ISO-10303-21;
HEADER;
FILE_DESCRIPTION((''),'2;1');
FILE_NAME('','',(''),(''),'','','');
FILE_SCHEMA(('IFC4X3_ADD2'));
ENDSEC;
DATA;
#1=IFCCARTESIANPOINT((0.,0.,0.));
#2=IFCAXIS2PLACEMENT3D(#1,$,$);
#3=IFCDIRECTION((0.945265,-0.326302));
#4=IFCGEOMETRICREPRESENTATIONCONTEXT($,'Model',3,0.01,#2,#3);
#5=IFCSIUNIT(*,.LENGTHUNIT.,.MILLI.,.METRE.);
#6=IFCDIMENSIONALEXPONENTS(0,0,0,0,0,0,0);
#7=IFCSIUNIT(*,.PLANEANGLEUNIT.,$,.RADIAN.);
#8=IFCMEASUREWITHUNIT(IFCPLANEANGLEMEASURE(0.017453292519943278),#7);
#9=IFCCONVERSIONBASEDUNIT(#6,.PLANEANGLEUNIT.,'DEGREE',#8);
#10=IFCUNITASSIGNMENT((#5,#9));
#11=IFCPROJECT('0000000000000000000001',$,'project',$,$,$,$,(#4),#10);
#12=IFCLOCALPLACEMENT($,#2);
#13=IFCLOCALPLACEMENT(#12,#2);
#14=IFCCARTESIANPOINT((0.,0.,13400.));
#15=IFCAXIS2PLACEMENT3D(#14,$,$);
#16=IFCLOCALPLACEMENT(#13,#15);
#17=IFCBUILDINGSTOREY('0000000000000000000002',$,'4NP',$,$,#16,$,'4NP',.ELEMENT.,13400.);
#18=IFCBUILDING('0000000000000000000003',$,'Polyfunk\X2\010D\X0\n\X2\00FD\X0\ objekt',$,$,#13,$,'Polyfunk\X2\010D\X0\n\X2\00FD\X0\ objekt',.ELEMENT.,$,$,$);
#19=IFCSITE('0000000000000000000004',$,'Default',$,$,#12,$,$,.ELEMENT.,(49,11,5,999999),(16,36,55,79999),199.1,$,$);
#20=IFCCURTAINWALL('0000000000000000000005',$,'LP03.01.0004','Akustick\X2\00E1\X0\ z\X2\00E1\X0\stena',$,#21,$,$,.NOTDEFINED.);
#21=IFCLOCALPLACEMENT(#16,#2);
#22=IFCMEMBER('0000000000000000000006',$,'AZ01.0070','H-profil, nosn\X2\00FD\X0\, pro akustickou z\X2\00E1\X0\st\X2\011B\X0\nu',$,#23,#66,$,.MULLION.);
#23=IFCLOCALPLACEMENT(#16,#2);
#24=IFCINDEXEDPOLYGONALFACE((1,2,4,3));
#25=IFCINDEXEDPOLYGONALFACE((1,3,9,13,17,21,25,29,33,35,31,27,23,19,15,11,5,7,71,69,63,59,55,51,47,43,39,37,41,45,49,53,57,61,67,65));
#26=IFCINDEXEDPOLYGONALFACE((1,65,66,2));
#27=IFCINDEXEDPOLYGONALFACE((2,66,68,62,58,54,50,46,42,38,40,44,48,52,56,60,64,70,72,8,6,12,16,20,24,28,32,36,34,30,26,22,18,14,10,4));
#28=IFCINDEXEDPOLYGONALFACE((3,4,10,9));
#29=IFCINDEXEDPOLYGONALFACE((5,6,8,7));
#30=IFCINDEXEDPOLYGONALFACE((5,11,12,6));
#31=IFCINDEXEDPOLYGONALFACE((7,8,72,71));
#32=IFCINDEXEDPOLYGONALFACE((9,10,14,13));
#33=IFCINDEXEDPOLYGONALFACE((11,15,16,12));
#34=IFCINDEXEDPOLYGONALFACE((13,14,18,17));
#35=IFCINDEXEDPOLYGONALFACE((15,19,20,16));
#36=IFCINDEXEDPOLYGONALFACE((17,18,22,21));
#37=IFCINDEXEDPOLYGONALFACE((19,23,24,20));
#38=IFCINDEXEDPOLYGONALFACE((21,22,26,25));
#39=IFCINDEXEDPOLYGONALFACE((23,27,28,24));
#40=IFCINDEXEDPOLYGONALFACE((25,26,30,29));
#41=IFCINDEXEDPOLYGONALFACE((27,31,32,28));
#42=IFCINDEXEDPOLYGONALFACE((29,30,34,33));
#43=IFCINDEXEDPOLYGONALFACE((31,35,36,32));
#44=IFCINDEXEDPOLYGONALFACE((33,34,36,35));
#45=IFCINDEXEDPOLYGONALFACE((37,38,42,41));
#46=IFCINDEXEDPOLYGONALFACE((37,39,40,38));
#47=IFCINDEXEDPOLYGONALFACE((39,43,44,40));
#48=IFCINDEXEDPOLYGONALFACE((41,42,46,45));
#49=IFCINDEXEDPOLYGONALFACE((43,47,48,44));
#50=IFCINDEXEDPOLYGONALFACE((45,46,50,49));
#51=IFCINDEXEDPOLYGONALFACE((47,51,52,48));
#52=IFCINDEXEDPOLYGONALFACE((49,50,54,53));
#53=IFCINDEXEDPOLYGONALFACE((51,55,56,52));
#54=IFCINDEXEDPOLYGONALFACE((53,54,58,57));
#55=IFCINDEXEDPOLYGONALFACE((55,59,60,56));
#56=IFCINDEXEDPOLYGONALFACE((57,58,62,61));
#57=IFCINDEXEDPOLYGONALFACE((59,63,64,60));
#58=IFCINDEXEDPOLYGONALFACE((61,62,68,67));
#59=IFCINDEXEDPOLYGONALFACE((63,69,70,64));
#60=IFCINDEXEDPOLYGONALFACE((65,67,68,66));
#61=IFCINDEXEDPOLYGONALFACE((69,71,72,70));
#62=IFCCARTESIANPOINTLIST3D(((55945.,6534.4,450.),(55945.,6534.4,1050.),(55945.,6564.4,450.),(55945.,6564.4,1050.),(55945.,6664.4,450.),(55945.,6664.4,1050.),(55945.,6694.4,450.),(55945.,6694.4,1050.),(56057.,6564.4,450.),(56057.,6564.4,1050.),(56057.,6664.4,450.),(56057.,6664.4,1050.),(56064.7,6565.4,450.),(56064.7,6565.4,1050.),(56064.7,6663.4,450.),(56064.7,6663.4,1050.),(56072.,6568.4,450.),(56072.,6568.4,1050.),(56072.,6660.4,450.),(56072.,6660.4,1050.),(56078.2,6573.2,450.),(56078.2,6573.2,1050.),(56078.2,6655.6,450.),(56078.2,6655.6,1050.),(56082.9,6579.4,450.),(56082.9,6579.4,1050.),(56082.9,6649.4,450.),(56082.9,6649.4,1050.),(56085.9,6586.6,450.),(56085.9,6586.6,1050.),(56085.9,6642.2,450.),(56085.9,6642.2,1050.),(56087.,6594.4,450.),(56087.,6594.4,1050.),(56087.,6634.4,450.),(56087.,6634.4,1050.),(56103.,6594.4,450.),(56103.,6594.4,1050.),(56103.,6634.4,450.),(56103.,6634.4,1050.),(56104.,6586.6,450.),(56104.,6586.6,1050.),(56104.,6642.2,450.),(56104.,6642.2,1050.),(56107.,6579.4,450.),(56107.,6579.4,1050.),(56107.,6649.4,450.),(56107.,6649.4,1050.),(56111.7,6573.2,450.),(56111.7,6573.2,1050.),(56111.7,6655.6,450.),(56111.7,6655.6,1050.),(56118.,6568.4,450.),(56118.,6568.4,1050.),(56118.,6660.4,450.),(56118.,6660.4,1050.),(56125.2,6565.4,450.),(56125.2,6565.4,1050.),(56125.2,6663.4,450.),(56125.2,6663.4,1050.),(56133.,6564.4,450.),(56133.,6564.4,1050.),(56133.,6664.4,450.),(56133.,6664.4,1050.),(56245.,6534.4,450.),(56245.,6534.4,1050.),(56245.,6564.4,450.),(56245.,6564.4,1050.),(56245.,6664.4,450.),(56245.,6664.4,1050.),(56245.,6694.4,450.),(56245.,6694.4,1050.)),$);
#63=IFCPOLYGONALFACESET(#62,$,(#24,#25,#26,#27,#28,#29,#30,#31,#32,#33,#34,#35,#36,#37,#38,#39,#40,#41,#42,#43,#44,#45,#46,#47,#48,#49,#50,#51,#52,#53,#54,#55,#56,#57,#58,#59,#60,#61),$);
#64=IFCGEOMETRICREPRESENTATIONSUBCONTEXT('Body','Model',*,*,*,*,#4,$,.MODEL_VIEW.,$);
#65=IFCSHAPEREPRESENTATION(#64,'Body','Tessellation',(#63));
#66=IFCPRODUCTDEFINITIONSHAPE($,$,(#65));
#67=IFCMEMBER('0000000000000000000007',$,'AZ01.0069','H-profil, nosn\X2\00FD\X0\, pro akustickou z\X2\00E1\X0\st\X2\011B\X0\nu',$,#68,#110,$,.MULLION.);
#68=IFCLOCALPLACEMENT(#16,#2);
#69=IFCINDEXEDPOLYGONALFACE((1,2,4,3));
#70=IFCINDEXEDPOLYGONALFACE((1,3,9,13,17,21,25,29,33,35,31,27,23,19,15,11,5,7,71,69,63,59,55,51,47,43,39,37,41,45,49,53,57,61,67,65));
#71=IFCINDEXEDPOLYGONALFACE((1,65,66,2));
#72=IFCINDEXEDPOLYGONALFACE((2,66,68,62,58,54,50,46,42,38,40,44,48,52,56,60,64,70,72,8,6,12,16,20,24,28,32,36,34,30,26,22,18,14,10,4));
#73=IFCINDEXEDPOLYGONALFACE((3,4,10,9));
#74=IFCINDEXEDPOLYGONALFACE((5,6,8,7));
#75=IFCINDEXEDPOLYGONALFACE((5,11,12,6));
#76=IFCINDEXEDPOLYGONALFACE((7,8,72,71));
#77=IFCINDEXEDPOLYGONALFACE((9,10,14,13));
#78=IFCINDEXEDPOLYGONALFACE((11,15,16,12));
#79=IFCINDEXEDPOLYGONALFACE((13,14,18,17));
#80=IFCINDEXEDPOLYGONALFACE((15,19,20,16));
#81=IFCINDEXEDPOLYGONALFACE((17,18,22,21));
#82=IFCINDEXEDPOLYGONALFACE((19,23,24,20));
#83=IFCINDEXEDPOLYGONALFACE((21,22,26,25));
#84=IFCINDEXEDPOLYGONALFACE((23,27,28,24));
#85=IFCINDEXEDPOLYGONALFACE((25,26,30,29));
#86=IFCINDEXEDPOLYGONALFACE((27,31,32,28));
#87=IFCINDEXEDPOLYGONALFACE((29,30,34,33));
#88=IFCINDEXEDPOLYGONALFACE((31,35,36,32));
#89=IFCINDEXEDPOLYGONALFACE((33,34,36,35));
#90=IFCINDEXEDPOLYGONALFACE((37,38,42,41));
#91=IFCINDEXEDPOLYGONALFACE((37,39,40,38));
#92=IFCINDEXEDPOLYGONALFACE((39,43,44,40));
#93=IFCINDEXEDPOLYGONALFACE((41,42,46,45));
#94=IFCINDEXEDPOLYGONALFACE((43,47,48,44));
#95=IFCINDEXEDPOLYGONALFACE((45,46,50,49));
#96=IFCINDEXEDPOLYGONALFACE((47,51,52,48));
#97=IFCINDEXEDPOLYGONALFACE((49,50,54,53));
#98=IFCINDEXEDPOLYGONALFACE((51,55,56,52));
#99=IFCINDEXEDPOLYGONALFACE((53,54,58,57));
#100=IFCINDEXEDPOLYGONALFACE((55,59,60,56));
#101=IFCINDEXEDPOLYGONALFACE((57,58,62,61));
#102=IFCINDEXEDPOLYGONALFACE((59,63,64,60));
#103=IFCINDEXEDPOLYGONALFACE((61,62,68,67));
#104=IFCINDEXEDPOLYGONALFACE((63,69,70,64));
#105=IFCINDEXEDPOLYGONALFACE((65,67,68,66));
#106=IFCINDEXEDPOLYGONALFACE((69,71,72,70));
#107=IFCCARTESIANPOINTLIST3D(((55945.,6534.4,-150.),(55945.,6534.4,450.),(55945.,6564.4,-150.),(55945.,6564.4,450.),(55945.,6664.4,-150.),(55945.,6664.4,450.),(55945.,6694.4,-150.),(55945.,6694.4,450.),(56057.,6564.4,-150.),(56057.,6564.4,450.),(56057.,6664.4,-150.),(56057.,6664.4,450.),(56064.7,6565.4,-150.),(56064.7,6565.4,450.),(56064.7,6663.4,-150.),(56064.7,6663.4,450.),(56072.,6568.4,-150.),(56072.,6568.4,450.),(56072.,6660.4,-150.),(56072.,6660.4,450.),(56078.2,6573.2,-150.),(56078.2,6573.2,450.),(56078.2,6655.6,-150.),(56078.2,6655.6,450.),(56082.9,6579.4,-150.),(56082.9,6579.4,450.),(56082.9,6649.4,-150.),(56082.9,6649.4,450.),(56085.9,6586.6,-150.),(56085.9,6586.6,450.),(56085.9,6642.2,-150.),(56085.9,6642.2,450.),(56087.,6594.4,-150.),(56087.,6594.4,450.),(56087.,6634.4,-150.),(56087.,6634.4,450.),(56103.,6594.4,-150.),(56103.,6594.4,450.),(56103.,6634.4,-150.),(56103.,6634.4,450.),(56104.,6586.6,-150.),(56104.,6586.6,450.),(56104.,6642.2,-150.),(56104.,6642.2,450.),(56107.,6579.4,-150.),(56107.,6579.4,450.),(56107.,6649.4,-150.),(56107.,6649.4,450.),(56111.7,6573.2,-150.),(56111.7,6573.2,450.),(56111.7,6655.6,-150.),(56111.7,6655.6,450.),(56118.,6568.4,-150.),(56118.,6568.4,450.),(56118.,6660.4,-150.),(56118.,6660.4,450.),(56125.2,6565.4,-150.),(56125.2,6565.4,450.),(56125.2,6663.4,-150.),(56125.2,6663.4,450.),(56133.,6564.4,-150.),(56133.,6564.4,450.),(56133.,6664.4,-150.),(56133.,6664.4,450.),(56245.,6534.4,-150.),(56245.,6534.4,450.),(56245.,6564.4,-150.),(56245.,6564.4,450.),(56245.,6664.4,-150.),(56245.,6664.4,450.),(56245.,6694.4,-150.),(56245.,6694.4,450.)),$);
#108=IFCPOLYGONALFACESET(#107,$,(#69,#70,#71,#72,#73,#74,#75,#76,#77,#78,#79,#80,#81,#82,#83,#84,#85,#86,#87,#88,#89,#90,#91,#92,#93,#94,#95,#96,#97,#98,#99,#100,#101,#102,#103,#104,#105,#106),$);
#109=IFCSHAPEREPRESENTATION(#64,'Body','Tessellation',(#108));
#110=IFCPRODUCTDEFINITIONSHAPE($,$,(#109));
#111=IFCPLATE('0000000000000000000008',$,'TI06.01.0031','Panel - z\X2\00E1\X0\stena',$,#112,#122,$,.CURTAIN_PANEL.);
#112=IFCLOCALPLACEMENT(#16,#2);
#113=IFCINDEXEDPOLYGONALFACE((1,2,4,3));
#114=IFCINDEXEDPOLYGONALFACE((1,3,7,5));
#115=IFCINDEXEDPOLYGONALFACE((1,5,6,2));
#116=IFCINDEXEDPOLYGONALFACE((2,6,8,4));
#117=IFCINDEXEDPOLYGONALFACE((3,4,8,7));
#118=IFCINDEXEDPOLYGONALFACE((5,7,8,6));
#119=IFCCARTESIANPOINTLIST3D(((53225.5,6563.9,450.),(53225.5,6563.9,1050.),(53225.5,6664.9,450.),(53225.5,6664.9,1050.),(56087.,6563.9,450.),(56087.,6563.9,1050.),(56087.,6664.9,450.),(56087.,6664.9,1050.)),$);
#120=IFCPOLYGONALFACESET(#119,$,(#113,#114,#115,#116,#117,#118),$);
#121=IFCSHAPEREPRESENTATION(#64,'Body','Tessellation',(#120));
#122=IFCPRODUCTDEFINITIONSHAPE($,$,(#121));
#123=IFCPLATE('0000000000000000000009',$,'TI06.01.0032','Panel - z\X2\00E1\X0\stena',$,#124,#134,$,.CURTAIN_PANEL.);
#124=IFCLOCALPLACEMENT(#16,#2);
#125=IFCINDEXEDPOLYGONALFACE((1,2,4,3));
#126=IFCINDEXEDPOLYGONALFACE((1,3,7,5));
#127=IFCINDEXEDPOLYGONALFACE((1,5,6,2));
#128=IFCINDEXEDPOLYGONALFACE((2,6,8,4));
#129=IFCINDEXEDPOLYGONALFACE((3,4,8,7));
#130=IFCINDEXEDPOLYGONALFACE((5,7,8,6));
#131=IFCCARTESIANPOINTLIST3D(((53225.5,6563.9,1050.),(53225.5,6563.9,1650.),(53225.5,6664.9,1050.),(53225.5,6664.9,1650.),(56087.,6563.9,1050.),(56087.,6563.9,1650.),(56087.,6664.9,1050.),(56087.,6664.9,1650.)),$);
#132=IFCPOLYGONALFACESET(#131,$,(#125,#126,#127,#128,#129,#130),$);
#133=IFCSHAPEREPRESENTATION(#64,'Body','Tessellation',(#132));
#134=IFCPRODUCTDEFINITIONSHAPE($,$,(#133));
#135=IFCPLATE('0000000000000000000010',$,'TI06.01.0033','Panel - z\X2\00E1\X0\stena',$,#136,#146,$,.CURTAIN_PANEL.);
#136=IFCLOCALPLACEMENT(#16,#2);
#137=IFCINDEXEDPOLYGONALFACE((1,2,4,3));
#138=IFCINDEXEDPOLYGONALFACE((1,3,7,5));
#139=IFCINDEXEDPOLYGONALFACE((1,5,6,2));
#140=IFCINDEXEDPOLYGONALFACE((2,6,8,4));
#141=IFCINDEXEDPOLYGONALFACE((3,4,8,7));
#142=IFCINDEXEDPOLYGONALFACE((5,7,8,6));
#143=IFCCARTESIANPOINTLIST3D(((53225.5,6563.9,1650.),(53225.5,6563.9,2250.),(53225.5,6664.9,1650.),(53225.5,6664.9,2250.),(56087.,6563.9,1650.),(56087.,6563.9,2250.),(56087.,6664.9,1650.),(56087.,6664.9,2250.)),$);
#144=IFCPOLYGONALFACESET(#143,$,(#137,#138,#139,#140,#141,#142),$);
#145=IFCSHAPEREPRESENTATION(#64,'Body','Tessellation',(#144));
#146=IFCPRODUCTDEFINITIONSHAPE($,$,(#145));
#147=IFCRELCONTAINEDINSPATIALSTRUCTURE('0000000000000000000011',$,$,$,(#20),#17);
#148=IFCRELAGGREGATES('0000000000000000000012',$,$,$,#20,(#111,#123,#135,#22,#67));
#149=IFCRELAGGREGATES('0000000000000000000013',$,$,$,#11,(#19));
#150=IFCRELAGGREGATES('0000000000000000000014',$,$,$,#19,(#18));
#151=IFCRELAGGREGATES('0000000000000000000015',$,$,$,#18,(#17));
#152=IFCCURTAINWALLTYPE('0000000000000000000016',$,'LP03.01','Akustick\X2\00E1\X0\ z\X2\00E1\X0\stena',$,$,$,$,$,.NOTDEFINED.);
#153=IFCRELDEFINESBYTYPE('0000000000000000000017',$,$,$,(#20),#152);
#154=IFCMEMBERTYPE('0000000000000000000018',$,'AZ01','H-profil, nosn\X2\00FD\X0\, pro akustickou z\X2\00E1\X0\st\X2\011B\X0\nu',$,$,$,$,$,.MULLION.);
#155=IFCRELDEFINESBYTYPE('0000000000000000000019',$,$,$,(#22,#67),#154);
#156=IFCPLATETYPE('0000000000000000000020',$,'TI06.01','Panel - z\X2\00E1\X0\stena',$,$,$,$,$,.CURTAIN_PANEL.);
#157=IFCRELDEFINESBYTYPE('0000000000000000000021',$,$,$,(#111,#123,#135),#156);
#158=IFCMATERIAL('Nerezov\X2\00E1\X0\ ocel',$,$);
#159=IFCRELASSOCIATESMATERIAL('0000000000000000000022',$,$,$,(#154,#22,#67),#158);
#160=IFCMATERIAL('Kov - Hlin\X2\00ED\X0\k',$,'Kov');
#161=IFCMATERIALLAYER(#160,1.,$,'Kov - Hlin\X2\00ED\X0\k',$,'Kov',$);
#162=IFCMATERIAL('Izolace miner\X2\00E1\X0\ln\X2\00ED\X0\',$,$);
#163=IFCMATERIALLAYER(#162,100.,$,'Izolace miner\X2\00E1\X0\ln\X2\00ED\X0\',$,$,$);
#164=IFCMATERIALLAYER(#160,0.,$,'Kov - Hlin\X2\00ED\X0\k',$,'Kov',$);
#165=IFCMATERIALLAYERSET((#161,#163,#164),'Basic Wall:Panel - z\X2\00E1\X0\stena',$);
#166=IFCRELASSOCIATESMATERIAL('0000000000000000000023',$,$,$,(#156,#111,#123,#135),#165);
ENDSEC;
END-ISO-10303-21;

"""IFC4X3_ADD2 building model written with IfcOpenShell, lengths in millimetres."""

from ifc_helpers import new_model, entity, si_unit, converted_unit, direction, frame, frame_2d, origin, origin_2d_with_axis, place, context, subcontext, project, spatial, polyline, circle_curve, parameter, trimmed, segment, composite_curve, rectangle, outline, extrude, source, transform, mapped, material, layer, layer_set, layer_usage, material_profile, profile_set, profile_usage, type_object, element, aggregate, save


model = new_model("IFC4X3_ADD2")

# Units and contexts
model_context = context("Model", 3, precision=0.01, world=origin(), true_north=direction((0.945265, -0.326302)))
body_context = subcontext(model_context, "Body", "Model", "MODEL_VIEW")
ifc_project = project(units=[si_unit("LENGTHUNIT", "METRE", prefix="MILLI"), converted_unit("PLANEANGLEUNIT", "DEGREE", entity("IfcPlaneAngleMeasure", 0.017453292519943278), si_unit("PLANEANGLEUNIT", "RADIAN"), dimensions=[0, 0, 0, 0, 0, 0, 0])], contexts=[model_context])

# Site, building, storey
site_placement = place(None, origin())
site = spatial("IfcSite", under=ifc_project, at=site_placement, Name="Default", CompositionType="ELEMENT", RefLatitude=(49, 11, 5, 999999), RefLongitude=(16, 36, 55, 79999), RefElevation=199.1)
building_placement = place(site_placement, origin())
building = spatial("IfcBuilding", under=site, at=building_placement, Name="Polyfunkčný objekt", LongName="Polyfunkčný objekt", CompositionType="ELEMENT")
storey_placement = place(building_placement, frame((0.0, 0.0, 13400.0)))
storey = spatial("IfcBuildingStorey", under=building, at=storey_placement, Name="4NP", LongName="4NP", CompositionType="ELEMENT", Elevation=13400.0)

# Curtain wall, members, plates
curtain_wall_type = type_object("IfcCurtainWallType", Name="LP03.01", Description="Akustická zástena", PredefinedType="NOTDEFINED")
curtain_wall_placement = place(storey_placement, frame((0.0, 0.0, -13400.0)))
curtain_wall = element("IfcCurtainWall", 1, at=curtain_wall_placement, inside=storey, type_object=curtain_wall_type, Name="LP03.01.0004", Description="Akustická zástena", PredefinedType="NOTDEFINED")
ifc_material_1 = material(Name="Nerezová ocel")
ifc_material_profile = material_profile(ifc_material_1, outline(composite_curve([segment(polyline([(50.0, -150.0), (80.0, -150.0)]), True, "CONTINUOUS"), segment(polyline([(80.0, -150.0), (80.0, 150.0)]), True, "CONTINUOUS"), segment(polyline([(80.0, 150.0), (50.0, 150.0)]), True, "CONTINUOUS"), segment(polyline([(50.0, 150.0), (50.0, 38.0)]), True, "CONTINUOUS"), segment(trimmed(circle_curve(frame_2d((20.0, 38.0), x_axis=(0.0, 1.0)), 30.0), [parameter(180.0)], [parameter(270.0)], True, "PARAMETER"), False, "CONTINUOUS"), segment(polyline([(20.0, 8.0), (-20.0, 8.0)]), True, "CONTINUOUS"), segment(trimmed(circle_curve(frame_2d((-20.0, 38.0), x_axis=(0.0, 1.0)), 30.0), [parameter(90.0)], [parameter(180.0)], True, "PARAMETER"), False, "CONTINUOUS"), segment(polyline([(-50.0, 38.0), (-50.0, 150.0)]), True, "CONTINUOUS"), segment(polyline([(-50.0, 150.0), (-80.0, 150.0)]), True, "CONTINUOUS"), segment(polyline([(-80.0, 150.0), (-80.0, -150.0)]), True, "CONTINUOUS"), segment(polyline([(-80.0, -150.0), (-50.0, -150.0)]), True, "CONTINUOUS"), segment(polyline([(-50.0, -150.0), (-50.0, -38.0)]), True, "CONTINUOUS"), segment(trimmed(circle_curve(frame_2d((-20.0, -38.0), x_axis=(0.0, 1.0)), 30.0), [parameter(0.0)], [parameter(90.0)], True, "PARAMETER"), False, "CONTINUOUS"), segment(polyline([(-20.0, -8.0), (20.0, -8.0)]), True, "CONTINUOUS"), segment(trimmed(circle_curve(frame_2d((20.0, -38.0), x_axis=(0.0, 1.0)), 30.0), [parameter(270.0)], [parameter(0.0)], True, "PARAMETER"), False, "CONTINUOUS"), segment(polyline([(50.0, -38.0), (50.0, -150.0)]), True, "CONTINUOUS")], self_intersect=False)), Name="Profil zástena")
ifc_profile_set = profile_set([ifc_material_profile], Name="Profil zástena")
ifc_profile_usage = profile_usage(ifc_profile_set)
member_type = type_object("IfcMemberType", Name="AZ01", Description="H-profil, nosný, pro akustickou zástěnu", PredefinedType="MULLION", material=ifc_profile_set)
shared_shape_1 = source(origin(), body_context, "Body", "SweptSolid", [
    extrude(outline(composite_curve([segment(polyline([(50.0, -150.0), (80.0, -150.0)]), True, "CONTINUOUS"), segment(polyline([(80.0, -150.0), (80.0, 150.0)]), True, "CONTINUOUS"), segment(polyline([(80.0, 150.0), (50.0, 150.0)]), True, "CONTINUOUS"), segment(polyline([(50.0, 150.0), (50.0, 38.0)]), True, "CONTINUOUS"), segment(trimmed(circle_curve(frame_2d((20.0, 38.0), x_axis=(0.0, 1.0)), 30.0), [parameter(180.0)], [parameter(270.0)], True, "PARAMETER"), False, "CONTINUOUS"), segment(polyline([(20.0, 8.0), (-20.0, 8.0)]), True, "CONTINUOUS"), segment(trimmed(circle_curve(frame_2d((-20.0, 38.0), x_axis=(0.0, 1.0)), 30.0), [parameter(90.0)], [parameter(180.0)], True, "PARAMETER"), False, "CONTINUOUS"), segment(polyline([(-50.0, 38.0), (-50.0, 150.0)]), True, "CONTINUOUS"), segment(polyline([(-50.0, 150.0), (-80.0, 150.0)]), True, "CONTINUOUS"), segment(polyline([(-80.0, 150.0), (-80.0, -150.0)]), True, "CONTINUOUS"), segment(polyline([(-80.0, -150.0), (-50.0, -150.0)]), True, "CONTINUOUS"), segment(polyline([(-50.0, -150.0), (-50.0, -38.0)]), True, "CONTINUOUS"), segment(trimmed(circle_curve(frame_2d((-20.0, -38.0), x_axis=(0.0, 1.0)), 30.0), [parameter(0.0)], [parameter(90.0)], True, "PARAMETER"), False, "CONTINUOUS"), segment(polyline([(-20.0, -8.0), (20.0, -8.0)]), True, "CONTINUOUS"), segment(trimmed(circle_curve(frame_2d((20.0, -38.0), x_axis=(0.0, 1.0)), 30.0), [parameter(270.0)], [parameter(0.0)], True, "PARAMETER"), False, "CONTINUOUS"), segment(polyline([(50.0, -38.0), (50.0, -150.0)]), True, "CONTINUOUS")], self_intersect=False)), frame((-150.0, 0.0, -600.0), z_axis=(0.0, 0.0, 1.0), x_axis=(0.0, -1.0, 0.0)), (0.0, 0.0, 1.0), 600.0),
])
member_1_placement = place(curtain_wall_placement, frame((56245.0, 6614.4, 13850.0), z_axis=(0.0, 0.0, -1.0), x_axis=(1.0, 0.0, 0.0)))
member_1 = element("IfcMember", 2, at=member_1_placement, type_object=member_type, material=ifc_profile_usage, Name="AZ01.0070", Description="H-profil, nosný, pro akustickou zástěnu", PredefinedType="MULLION", context=body_context, shape_type="MappedRepresentation", body=[
    mapped(shared_shape_1, transform((0.0, 0.0, 0.0), scale=1.0)),
])
shared_shape_2 = source(origin(), body_context, "Body", "SweptSolid", [
    extrude(outline(composite_curve([segment(polyline([(50.0, -150.0), (80.0, -150.0)]), True, "CONTINUOUS"), segment(polyline([(80.0, -150.0), (80.0, 150.0)]), True, "CONTINUOUS"), segment(polyline([(80.0, 150.0), (50.0, 150.0)]), True, "CONTINUOUS"), segment(polyline([(50.0, 150.0), (50.0, 38.0)]), True, "CONTINUOUS"), segment(trimmed(circle_curve(frame_2d((20.0, 38.0), x_axis=(0.0, 1.0)), 30.0), [parameter(180.0)], [parameter(270.0)], True, "PARAMETER"), False, "CONTINUOUS"), segment(polyline([(20.0, 8.0), (-20.0, 8.0)]), True, "CONTINUOUS"), segment(trimmed(circle_curve(frame_2d((-20.0, 38.0), x_axis=(0.0, 1.0)), 30.0), [parameter(90.0)], [parameter(180.0)], True, "PARAMETER"), False, "CONTINUOUS"), segment(polyline([(-50.0, 38.0), (-50.0, 150.0)]), True, "CONTINUOUS"), segment(polyline([(-50.0, 150.0), (-80.0, 150.0)]), True, "CONTINUOUS"), segment(polyline([(-80.0, 150.0), (-80.0, -150.0)]), True, "CONTINUOUS"), segment(polyline([(-80.0, -150.0), (-50.0, -150.0)]), True, "CONTINUOUS"), segment(polyline([(-50.0, -150.0), (-50.0, -38.0)]), True, "CONTINUOUS"), segment(trimmed(circle_curve(frame_2d((-20.0, -38.0), x_axis=(0.0, 1.0)), 30.0), [parameter(0.0)], [parameter(90.0)], True, "PARAMETER"), False, "CONTINUOUS"), segment(polyline([(-20.0, -8.0), (20.0, -8.0)]), True, "CONTINUOUS"), segment(trimmed(circle_curve(frame_2d((20.0, -38.0), x_axis=(0.0, 1.0)), 30.0), [parameter(270.0)], [parameter(0.0)], True, "PARAMETER"), False, "CONTINUOUS"), segment(polyline([(50.0, -38.0), (50.0, -150.0)]), True, "CONTINUOUS")], self_intersect=False)), frame((-150.0, 0.0, -600.0), z_axis=(0.0, 0.0, 1.0), x_axis=(0.0, -1.0, 0.0)), (0.0, 0.0, 1.0), 600.0),
])
member_2_placement = place(curtain_wall_placement, frame((56245.0, 6614.4, 13250.0), z_axis=(0.0, 0.0, -1.0), x_axis=(1.0, 0.0, 0.0)))
member_2 = element("IfcMember", 3, at=member_2_placement, type_object=member_type, material=ifc_profile_usage, Name="AZ01.0069", Description="H-profil, nosný, pro akustickou zástěnu", PredefinedType="MULLION", context=body_context, shape_type="MappedRepresentation", body=[
    mapped(shared_shape_2, transform((0.0, 0.0, 0.0), scale=1.0)),
])
ifc_material_2 = material(Name="Kov - Hliník", Category="Kov")
ifc_layer_1 = layer(ifc_material_2, 1.0, Name="Kov - Hliník", Category="Kov")
ifc_material_3 = material(Name="Izolace minerální")
ifc_layer_2 = layer(ifc_material_3, 100.0, Name="Izolace minerální")
ifc_layer_3 = layer(ifc_material_2, 0.0, Name="Kov - Hliník", Category="Kov")
ifc_layer_set_1 = layer_set([ifc_layer_1, ifc_layer_2, ifc_layer_3], Name="Basic Wall:Panel - zástena")
ifc_layer_usage_1 = layer_usage(ifc_layer_set_1, "AXIS2", "POSITIVE", -50.5)
plate_type = type_object("IfcPlateType", Name="TI06.01", Description="Panel - zástena", PredefinedType="CURTAIN_PANEL", material=ifc_layer_set_1)
plate_1_placement = place(storey_placement, frame((53225.5, 6614.4, 450.0)))
plate_1 = element("IfcPlate", 4, at=plate_1_placement, type_object=plate_type, material=ifc_layer_usage_1, Name="TI06.01.0031", Description="Panel - zástena", PredefinedType="CURTAIN_PANEL", context=body_context, shape_type="SweptSolid", body=[
    extrude(rectangle(XDim=101.0, YDim=2861.5, at=origin_2d_with_axis()), frame((1430.8, 0.0, 0.0), z_axis=(0.0, 0.0, 1.0), x_axis=(0.0, 1.0, 0.0)), (0.0, 0.0, 1.0), 600.0),
])
ifc_layer_usage_2 = layer_usage(ifc_layer_set_1, "AXIS2", "POSITIVE", -50.5)
plate_2_placement = place(storey_placement, frame((53225.5, 6614.4, 1050.0)))
plate_2 = element("IfcPlate", 5, at=plate_2_placement, type_object=plate_type, material=ifc_layer_usage_2, Name="TI06.01.0032", Description="Panel - zástena", PredefinedType="CURTAIN_PANEL", context=body_context, shape_type="SweptSolid", body=[
    extrude(rectangle(XDim=101.0, YDim=2861.5, at=frame_2d((0.0, 0.0), x_axis=(1.0, 0.0))), frame((1430.7, 0.0, 0.0), z_axis=(0.0, 0.0, 1.0), x_axis=(0.0, 1.0, 0.0)), (0.0, 0.0, 1.0), 600.0),
])
ifc_layer_usage_3 = layer_usage(ifc_layer_set_1, "AXIS2", "POSITIVE", -50.5)
plate_3_placement = place(storey_placement, frame((53225.5, 6614.4, 1650.0)))
plate_3 = element("IfcPlate", 6, at=plate_3_placement, type_object=plate_type, material=ifc_layer_usage_3, Name="TI06.01.0033", Description="Panel - zástena", PredefinedType="CURTAIN_PANEL", context=body_context, shape_type="SweptSolid", body=[
    extrude(rectangle(XDim=101.0, YDim=2861.5, at=frame_2d((0.0, 0.0), x_axis=(1.0, 0.0))), frame((1430.7, 0.0, 0.0), z_axis=(0.0, 0.0, 1.0), x_axis=(0.0, 1.0, 0.0)), (0.0, 0.0, 1.0), 600.0),
])
aggregate(curtain_wall, [plate_1, plate_2, plate_3, member_1, member_2])

save(model, "model.ifc")
